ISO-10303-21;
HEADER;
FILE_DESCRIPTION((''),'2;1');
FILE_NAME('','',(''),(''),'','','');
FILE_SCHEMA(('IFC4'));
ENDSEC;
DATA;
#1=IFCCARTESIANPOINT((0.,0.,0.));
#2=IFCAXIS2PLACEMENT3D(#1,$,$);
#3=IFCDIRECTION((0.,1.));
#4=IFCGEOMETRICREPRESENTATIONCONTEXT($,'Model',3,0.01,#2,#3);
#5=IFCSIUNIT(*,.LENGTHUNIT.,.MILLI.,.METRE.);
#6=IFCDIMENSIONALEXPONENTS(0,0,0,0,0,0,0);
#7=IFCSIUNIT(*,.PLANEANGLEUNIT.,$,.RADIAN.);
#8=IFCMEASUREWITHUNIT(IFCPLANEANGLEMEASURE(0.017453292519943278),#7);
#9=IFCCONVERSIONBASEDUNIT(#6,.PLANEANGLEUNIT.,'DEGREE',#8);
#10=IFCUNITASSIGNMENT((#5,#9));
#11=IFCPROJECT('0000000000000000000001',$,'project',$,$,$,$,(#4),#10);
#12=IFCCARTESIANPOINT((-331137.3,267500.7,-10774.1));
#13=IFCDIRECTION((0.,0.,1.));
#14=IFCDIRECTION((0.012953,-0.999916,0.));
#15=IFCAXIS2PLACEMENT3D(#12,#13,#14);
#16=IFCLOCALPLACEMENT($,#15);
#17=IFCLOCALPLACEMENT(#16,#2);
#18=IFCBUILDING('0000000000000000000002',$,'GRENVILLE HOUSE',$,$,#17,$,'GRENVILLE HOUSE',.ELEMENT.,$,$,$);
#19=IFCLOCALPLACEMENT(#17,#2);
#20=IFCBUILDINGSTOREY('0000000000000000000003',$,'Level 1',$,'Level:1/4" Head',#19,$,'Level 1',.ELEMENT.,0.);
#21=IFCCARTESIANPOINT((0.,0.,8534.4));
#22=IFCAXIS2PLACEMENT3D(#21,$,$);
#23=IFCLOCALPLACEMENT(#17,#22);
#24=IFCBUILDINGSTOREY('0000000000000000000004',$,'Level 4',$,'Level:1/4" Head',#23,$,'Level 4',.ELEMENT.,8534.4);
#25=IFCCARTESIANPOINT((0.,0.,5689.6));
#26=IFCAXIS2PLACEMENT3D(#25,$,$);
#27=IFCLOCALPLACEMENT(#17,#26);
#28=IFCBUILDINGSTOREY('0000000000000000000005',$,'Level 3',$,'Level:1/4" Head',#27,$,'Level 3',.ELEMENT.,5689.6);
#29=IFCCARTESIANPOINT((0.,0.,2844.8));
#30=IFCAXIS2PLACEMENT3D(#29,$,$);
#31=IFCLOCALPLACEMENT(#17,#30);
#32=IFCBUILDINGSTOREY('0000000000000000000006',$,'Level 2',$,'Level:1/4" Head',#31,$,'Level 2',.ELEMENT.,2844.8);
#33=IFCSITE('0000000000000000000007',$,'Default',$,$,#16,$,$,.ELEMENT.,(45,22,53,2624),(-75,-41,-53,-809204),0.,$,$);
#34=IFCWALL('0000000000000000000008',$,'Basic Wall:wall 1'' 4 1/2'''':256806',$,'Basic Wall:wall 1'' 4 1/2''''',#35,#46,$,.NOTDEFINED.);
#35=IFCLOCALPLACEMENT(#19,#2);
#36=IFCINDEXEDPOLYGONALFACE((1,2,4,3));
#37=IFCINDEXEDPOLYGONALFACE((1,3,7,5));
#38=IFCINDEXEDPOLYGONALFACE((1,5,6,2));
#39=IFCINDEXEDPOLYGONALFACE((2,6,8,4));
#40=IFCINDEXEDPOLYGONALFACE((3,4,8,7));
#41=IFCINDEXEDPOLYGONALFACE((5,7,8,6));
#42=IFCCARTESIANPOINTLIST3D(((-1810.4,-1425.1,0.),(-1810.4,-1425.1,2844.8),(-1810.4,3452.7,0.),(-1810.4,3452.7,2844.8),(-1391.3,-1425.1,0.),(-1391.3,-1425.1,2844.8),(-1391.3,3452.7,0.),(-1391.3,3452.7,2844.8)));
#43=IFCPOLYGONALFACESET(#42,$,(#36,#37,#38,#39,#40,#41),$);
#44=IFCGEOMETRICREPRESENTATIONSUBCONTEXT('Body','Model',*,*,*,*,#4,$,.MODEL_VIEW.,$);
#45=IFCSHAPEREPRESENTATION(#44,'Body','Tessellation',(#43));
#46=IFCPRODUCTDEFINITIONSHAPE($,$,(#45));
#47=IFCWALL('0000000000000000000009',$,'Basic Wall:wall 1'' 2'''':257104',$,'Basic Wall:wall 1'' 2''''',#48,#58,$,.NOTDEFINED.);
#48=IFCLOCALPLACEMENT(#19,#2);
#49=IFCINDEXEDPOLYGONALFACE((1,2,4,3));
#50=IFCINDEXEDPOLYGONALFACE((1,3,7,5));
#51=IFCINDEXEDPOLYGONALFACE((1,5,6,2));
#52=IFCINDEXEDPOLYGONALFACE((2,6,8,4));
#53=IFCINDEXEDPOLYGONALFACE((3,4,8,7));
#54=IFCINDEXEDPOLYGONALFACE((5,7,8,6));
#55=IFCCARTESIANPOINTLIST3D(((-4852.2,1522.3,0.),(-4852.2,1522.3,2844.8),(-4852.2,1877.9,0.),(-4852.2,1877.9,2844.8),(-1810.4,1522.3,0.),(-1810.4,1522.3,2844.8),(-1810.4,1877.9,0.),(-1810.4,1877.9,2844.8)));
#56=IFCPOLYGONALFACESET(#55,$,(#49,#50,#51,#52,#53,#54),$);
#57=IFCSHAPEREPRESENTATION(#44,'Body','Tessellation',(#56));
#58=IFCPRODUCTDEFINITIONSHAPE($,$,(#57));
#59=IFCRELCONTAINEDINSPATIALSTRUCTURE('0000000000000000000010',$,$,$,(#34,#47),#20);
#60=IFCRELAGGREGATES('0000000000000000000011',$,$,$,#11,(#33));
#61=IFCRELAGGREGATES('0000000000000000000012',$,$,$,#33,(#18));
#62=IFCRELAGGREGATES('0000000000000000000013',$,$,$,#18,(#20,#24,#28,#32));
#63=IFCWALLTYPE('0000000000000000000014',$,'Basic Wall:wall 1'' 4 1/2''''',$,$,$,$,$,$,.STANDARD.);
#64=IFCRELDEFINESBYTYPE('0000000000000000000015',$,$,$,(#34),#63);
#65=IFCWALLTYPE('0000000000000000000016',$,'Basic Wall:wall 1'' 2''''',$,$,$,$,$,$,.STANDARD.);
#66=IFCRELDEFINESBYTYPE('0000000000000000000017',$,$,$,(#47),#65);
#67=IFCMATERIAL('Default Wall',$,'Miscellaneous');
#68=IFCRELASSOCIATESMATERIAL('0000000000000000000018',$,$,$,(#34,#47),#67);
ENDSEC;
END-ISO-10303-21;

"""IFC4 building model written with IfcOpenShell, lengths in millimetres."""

from ifc_helpers import new_model, entity, si_unit, converted_unit, direction, frame, origin, place, context, subcontext, project, spatial, indexed_curve, outline, extrude, material, type_object, element, save


model = new_model("IFC4")

# Units and contexts
model_context = context("Model", 3, precision=0.01, world=origin(), true_north=direction((0.0, 1.0)))
body_context = subcontext(model_context, "Body", "Model", "MODEL_VIEW")
ifc_project = project(units=[si_unit("LENGTHUNIT", "METRE", prefix="MILLI"), converted_unit("PLANEANGLEUNIT", "DEGREE", entity("IfcPlaneAngleMeasure", 0.017453292519943278), si_unit("PLANEANGLEUNIT", "RADIAN"), dimensions=[0, 0, 0, 0, 0, 0, 0])], contexts=[model_context])

# Site, building, storey
site_placement = place(None, frame((-331137.3, 267500.7, -10774.1), z_axis=(0.0, 0.0, 1.0), x_axis=(0.012953, -0.999916, 0.0)))
site = spatial("IfcSite", under=ifc_project, at=site_placement, Name="Default", CompositionType="ELEMENT", RefLatitude=(45, 22, 53, 2624), RefLongitude=(-75, -41, -53, -809204), RefElevation=0.0)
building_placement = place(site_placement, origin())
building = spatial("IfcBuilding", under=site, at=building_placement, Name="GRENVILLE HOUSE", LongName="GRENVILLE HOUSE", CompositionType="ELEMENT")
storey_1_placement = place(building_placement, origin())
storey_1 = spatial("IfcBuildingStorey", under=building, at=storey_1_placement, Name="Level 1", ObjectType="Level:1/4\" Head", LongName="Level 1", CompositionType="ELEMENT", Elevation=0.0)

# Shared definitions
storey_2_placement = place(building_placement, frame((0.0, 0.0, 8534.4)))
storey_2 = spatial("IfcBuildingStorey", under=building, at=storey_2_placement, Name="Level 4", ObjectType="Level:1/4\" Head", LongName="Level 4", CompositionType="ELEMENT", Elevation=8534.4)

# Shared definitions
storey_3_placement = place(building_placement, frame((0.0, 0.0, 5689.6)))
storey_3 = spatial("IfcBuildingStorey", under=building, at=storey_3_placement, Name="Level 3", ObjectType="Level:1/4\" Head", LongName="Level 3", CompositionType="ELEMENT", Elevation=5689.6)

# Shared definitions
storey_4_placement = place(building_placement, frame((0.0, 0.0, 2844.8)))
storey_4 = spatial("IfcBuildingStorey", under=building, at=storey_4_placement, Name="Level 2", ObjectType="Level:1/4\" Head", LongName="Level 2", CompositionType="ELEMENT", Elevation=2844.8)

# Walls
ifc_material_1 = material(Name="Default Wall", Category="Miscellaneous")
wall_type_1 = type_object("IfcWallType", Name="Basic Wall:wall 1' 4 1/2''", PredefinedType="STANDARD")
wall_1_placement = place(storey_1_placement, frame((-1600.8, 3452.7, 0.0), z_axis=(0.0, 0.0, 1.0), x_axis=(0.0, -1.0, 0.0)))
element("IfcWall", 1, at=wall_1_placement, inside=storey_1, type_object=wall_type_1, material=ifc_material_1, Name="Basic Wall:wall 1' 4 1/2'':256806", ObjectType="Basic Wall:wall 1' 4 1/2''", PredefinedType="NOTDEFINED", context=body_context, shape_type="SweptSolid", body=[
    extrude(outline(indexed_curve([(4877.8, 209.6), (0.0, 209.6), (0.0, -209.6), (4877.8, -209.5), (4877.8, 209.6)], self_intersect=False)), origin(), (0.0, 0.0, 1.0), 2844.8),
])
wall_type_2 = type_object("IfcWallType", Name="Basic Wall:wall 1' 2''", PredefinedType="STANDARD")
wall_2_placement = place(storey_1_placement, frame((-1810.4, 1700.1, 0.0), z_axis=(0.0, 0.0, 1.0), x_axis=(-1.0, 0.0, 0.0)))
element("IfcWall", 2, at=wall_2_placement, inside=storey_1, type_object=wall_type_2, material=ifc_material_1, Name="Basic Wall:wall 1' 2'':257104", ObjectType="Basic Wall:wall 1' 2''", PredefinedType="NOTDEFINED", context=body_context, shape_type="SweptSolid", body=[
    extrude(outline(indexed_curve([(3041.9, 177.8), (0.0, 177.8), (0.0, -177.8), (3041.9, -177.8), (3041.9, 177.8)], self_intersect=False)), origin(), (0.0, 0.0, 1.0), 2844.8),
])

save(model, "model.ifc")
